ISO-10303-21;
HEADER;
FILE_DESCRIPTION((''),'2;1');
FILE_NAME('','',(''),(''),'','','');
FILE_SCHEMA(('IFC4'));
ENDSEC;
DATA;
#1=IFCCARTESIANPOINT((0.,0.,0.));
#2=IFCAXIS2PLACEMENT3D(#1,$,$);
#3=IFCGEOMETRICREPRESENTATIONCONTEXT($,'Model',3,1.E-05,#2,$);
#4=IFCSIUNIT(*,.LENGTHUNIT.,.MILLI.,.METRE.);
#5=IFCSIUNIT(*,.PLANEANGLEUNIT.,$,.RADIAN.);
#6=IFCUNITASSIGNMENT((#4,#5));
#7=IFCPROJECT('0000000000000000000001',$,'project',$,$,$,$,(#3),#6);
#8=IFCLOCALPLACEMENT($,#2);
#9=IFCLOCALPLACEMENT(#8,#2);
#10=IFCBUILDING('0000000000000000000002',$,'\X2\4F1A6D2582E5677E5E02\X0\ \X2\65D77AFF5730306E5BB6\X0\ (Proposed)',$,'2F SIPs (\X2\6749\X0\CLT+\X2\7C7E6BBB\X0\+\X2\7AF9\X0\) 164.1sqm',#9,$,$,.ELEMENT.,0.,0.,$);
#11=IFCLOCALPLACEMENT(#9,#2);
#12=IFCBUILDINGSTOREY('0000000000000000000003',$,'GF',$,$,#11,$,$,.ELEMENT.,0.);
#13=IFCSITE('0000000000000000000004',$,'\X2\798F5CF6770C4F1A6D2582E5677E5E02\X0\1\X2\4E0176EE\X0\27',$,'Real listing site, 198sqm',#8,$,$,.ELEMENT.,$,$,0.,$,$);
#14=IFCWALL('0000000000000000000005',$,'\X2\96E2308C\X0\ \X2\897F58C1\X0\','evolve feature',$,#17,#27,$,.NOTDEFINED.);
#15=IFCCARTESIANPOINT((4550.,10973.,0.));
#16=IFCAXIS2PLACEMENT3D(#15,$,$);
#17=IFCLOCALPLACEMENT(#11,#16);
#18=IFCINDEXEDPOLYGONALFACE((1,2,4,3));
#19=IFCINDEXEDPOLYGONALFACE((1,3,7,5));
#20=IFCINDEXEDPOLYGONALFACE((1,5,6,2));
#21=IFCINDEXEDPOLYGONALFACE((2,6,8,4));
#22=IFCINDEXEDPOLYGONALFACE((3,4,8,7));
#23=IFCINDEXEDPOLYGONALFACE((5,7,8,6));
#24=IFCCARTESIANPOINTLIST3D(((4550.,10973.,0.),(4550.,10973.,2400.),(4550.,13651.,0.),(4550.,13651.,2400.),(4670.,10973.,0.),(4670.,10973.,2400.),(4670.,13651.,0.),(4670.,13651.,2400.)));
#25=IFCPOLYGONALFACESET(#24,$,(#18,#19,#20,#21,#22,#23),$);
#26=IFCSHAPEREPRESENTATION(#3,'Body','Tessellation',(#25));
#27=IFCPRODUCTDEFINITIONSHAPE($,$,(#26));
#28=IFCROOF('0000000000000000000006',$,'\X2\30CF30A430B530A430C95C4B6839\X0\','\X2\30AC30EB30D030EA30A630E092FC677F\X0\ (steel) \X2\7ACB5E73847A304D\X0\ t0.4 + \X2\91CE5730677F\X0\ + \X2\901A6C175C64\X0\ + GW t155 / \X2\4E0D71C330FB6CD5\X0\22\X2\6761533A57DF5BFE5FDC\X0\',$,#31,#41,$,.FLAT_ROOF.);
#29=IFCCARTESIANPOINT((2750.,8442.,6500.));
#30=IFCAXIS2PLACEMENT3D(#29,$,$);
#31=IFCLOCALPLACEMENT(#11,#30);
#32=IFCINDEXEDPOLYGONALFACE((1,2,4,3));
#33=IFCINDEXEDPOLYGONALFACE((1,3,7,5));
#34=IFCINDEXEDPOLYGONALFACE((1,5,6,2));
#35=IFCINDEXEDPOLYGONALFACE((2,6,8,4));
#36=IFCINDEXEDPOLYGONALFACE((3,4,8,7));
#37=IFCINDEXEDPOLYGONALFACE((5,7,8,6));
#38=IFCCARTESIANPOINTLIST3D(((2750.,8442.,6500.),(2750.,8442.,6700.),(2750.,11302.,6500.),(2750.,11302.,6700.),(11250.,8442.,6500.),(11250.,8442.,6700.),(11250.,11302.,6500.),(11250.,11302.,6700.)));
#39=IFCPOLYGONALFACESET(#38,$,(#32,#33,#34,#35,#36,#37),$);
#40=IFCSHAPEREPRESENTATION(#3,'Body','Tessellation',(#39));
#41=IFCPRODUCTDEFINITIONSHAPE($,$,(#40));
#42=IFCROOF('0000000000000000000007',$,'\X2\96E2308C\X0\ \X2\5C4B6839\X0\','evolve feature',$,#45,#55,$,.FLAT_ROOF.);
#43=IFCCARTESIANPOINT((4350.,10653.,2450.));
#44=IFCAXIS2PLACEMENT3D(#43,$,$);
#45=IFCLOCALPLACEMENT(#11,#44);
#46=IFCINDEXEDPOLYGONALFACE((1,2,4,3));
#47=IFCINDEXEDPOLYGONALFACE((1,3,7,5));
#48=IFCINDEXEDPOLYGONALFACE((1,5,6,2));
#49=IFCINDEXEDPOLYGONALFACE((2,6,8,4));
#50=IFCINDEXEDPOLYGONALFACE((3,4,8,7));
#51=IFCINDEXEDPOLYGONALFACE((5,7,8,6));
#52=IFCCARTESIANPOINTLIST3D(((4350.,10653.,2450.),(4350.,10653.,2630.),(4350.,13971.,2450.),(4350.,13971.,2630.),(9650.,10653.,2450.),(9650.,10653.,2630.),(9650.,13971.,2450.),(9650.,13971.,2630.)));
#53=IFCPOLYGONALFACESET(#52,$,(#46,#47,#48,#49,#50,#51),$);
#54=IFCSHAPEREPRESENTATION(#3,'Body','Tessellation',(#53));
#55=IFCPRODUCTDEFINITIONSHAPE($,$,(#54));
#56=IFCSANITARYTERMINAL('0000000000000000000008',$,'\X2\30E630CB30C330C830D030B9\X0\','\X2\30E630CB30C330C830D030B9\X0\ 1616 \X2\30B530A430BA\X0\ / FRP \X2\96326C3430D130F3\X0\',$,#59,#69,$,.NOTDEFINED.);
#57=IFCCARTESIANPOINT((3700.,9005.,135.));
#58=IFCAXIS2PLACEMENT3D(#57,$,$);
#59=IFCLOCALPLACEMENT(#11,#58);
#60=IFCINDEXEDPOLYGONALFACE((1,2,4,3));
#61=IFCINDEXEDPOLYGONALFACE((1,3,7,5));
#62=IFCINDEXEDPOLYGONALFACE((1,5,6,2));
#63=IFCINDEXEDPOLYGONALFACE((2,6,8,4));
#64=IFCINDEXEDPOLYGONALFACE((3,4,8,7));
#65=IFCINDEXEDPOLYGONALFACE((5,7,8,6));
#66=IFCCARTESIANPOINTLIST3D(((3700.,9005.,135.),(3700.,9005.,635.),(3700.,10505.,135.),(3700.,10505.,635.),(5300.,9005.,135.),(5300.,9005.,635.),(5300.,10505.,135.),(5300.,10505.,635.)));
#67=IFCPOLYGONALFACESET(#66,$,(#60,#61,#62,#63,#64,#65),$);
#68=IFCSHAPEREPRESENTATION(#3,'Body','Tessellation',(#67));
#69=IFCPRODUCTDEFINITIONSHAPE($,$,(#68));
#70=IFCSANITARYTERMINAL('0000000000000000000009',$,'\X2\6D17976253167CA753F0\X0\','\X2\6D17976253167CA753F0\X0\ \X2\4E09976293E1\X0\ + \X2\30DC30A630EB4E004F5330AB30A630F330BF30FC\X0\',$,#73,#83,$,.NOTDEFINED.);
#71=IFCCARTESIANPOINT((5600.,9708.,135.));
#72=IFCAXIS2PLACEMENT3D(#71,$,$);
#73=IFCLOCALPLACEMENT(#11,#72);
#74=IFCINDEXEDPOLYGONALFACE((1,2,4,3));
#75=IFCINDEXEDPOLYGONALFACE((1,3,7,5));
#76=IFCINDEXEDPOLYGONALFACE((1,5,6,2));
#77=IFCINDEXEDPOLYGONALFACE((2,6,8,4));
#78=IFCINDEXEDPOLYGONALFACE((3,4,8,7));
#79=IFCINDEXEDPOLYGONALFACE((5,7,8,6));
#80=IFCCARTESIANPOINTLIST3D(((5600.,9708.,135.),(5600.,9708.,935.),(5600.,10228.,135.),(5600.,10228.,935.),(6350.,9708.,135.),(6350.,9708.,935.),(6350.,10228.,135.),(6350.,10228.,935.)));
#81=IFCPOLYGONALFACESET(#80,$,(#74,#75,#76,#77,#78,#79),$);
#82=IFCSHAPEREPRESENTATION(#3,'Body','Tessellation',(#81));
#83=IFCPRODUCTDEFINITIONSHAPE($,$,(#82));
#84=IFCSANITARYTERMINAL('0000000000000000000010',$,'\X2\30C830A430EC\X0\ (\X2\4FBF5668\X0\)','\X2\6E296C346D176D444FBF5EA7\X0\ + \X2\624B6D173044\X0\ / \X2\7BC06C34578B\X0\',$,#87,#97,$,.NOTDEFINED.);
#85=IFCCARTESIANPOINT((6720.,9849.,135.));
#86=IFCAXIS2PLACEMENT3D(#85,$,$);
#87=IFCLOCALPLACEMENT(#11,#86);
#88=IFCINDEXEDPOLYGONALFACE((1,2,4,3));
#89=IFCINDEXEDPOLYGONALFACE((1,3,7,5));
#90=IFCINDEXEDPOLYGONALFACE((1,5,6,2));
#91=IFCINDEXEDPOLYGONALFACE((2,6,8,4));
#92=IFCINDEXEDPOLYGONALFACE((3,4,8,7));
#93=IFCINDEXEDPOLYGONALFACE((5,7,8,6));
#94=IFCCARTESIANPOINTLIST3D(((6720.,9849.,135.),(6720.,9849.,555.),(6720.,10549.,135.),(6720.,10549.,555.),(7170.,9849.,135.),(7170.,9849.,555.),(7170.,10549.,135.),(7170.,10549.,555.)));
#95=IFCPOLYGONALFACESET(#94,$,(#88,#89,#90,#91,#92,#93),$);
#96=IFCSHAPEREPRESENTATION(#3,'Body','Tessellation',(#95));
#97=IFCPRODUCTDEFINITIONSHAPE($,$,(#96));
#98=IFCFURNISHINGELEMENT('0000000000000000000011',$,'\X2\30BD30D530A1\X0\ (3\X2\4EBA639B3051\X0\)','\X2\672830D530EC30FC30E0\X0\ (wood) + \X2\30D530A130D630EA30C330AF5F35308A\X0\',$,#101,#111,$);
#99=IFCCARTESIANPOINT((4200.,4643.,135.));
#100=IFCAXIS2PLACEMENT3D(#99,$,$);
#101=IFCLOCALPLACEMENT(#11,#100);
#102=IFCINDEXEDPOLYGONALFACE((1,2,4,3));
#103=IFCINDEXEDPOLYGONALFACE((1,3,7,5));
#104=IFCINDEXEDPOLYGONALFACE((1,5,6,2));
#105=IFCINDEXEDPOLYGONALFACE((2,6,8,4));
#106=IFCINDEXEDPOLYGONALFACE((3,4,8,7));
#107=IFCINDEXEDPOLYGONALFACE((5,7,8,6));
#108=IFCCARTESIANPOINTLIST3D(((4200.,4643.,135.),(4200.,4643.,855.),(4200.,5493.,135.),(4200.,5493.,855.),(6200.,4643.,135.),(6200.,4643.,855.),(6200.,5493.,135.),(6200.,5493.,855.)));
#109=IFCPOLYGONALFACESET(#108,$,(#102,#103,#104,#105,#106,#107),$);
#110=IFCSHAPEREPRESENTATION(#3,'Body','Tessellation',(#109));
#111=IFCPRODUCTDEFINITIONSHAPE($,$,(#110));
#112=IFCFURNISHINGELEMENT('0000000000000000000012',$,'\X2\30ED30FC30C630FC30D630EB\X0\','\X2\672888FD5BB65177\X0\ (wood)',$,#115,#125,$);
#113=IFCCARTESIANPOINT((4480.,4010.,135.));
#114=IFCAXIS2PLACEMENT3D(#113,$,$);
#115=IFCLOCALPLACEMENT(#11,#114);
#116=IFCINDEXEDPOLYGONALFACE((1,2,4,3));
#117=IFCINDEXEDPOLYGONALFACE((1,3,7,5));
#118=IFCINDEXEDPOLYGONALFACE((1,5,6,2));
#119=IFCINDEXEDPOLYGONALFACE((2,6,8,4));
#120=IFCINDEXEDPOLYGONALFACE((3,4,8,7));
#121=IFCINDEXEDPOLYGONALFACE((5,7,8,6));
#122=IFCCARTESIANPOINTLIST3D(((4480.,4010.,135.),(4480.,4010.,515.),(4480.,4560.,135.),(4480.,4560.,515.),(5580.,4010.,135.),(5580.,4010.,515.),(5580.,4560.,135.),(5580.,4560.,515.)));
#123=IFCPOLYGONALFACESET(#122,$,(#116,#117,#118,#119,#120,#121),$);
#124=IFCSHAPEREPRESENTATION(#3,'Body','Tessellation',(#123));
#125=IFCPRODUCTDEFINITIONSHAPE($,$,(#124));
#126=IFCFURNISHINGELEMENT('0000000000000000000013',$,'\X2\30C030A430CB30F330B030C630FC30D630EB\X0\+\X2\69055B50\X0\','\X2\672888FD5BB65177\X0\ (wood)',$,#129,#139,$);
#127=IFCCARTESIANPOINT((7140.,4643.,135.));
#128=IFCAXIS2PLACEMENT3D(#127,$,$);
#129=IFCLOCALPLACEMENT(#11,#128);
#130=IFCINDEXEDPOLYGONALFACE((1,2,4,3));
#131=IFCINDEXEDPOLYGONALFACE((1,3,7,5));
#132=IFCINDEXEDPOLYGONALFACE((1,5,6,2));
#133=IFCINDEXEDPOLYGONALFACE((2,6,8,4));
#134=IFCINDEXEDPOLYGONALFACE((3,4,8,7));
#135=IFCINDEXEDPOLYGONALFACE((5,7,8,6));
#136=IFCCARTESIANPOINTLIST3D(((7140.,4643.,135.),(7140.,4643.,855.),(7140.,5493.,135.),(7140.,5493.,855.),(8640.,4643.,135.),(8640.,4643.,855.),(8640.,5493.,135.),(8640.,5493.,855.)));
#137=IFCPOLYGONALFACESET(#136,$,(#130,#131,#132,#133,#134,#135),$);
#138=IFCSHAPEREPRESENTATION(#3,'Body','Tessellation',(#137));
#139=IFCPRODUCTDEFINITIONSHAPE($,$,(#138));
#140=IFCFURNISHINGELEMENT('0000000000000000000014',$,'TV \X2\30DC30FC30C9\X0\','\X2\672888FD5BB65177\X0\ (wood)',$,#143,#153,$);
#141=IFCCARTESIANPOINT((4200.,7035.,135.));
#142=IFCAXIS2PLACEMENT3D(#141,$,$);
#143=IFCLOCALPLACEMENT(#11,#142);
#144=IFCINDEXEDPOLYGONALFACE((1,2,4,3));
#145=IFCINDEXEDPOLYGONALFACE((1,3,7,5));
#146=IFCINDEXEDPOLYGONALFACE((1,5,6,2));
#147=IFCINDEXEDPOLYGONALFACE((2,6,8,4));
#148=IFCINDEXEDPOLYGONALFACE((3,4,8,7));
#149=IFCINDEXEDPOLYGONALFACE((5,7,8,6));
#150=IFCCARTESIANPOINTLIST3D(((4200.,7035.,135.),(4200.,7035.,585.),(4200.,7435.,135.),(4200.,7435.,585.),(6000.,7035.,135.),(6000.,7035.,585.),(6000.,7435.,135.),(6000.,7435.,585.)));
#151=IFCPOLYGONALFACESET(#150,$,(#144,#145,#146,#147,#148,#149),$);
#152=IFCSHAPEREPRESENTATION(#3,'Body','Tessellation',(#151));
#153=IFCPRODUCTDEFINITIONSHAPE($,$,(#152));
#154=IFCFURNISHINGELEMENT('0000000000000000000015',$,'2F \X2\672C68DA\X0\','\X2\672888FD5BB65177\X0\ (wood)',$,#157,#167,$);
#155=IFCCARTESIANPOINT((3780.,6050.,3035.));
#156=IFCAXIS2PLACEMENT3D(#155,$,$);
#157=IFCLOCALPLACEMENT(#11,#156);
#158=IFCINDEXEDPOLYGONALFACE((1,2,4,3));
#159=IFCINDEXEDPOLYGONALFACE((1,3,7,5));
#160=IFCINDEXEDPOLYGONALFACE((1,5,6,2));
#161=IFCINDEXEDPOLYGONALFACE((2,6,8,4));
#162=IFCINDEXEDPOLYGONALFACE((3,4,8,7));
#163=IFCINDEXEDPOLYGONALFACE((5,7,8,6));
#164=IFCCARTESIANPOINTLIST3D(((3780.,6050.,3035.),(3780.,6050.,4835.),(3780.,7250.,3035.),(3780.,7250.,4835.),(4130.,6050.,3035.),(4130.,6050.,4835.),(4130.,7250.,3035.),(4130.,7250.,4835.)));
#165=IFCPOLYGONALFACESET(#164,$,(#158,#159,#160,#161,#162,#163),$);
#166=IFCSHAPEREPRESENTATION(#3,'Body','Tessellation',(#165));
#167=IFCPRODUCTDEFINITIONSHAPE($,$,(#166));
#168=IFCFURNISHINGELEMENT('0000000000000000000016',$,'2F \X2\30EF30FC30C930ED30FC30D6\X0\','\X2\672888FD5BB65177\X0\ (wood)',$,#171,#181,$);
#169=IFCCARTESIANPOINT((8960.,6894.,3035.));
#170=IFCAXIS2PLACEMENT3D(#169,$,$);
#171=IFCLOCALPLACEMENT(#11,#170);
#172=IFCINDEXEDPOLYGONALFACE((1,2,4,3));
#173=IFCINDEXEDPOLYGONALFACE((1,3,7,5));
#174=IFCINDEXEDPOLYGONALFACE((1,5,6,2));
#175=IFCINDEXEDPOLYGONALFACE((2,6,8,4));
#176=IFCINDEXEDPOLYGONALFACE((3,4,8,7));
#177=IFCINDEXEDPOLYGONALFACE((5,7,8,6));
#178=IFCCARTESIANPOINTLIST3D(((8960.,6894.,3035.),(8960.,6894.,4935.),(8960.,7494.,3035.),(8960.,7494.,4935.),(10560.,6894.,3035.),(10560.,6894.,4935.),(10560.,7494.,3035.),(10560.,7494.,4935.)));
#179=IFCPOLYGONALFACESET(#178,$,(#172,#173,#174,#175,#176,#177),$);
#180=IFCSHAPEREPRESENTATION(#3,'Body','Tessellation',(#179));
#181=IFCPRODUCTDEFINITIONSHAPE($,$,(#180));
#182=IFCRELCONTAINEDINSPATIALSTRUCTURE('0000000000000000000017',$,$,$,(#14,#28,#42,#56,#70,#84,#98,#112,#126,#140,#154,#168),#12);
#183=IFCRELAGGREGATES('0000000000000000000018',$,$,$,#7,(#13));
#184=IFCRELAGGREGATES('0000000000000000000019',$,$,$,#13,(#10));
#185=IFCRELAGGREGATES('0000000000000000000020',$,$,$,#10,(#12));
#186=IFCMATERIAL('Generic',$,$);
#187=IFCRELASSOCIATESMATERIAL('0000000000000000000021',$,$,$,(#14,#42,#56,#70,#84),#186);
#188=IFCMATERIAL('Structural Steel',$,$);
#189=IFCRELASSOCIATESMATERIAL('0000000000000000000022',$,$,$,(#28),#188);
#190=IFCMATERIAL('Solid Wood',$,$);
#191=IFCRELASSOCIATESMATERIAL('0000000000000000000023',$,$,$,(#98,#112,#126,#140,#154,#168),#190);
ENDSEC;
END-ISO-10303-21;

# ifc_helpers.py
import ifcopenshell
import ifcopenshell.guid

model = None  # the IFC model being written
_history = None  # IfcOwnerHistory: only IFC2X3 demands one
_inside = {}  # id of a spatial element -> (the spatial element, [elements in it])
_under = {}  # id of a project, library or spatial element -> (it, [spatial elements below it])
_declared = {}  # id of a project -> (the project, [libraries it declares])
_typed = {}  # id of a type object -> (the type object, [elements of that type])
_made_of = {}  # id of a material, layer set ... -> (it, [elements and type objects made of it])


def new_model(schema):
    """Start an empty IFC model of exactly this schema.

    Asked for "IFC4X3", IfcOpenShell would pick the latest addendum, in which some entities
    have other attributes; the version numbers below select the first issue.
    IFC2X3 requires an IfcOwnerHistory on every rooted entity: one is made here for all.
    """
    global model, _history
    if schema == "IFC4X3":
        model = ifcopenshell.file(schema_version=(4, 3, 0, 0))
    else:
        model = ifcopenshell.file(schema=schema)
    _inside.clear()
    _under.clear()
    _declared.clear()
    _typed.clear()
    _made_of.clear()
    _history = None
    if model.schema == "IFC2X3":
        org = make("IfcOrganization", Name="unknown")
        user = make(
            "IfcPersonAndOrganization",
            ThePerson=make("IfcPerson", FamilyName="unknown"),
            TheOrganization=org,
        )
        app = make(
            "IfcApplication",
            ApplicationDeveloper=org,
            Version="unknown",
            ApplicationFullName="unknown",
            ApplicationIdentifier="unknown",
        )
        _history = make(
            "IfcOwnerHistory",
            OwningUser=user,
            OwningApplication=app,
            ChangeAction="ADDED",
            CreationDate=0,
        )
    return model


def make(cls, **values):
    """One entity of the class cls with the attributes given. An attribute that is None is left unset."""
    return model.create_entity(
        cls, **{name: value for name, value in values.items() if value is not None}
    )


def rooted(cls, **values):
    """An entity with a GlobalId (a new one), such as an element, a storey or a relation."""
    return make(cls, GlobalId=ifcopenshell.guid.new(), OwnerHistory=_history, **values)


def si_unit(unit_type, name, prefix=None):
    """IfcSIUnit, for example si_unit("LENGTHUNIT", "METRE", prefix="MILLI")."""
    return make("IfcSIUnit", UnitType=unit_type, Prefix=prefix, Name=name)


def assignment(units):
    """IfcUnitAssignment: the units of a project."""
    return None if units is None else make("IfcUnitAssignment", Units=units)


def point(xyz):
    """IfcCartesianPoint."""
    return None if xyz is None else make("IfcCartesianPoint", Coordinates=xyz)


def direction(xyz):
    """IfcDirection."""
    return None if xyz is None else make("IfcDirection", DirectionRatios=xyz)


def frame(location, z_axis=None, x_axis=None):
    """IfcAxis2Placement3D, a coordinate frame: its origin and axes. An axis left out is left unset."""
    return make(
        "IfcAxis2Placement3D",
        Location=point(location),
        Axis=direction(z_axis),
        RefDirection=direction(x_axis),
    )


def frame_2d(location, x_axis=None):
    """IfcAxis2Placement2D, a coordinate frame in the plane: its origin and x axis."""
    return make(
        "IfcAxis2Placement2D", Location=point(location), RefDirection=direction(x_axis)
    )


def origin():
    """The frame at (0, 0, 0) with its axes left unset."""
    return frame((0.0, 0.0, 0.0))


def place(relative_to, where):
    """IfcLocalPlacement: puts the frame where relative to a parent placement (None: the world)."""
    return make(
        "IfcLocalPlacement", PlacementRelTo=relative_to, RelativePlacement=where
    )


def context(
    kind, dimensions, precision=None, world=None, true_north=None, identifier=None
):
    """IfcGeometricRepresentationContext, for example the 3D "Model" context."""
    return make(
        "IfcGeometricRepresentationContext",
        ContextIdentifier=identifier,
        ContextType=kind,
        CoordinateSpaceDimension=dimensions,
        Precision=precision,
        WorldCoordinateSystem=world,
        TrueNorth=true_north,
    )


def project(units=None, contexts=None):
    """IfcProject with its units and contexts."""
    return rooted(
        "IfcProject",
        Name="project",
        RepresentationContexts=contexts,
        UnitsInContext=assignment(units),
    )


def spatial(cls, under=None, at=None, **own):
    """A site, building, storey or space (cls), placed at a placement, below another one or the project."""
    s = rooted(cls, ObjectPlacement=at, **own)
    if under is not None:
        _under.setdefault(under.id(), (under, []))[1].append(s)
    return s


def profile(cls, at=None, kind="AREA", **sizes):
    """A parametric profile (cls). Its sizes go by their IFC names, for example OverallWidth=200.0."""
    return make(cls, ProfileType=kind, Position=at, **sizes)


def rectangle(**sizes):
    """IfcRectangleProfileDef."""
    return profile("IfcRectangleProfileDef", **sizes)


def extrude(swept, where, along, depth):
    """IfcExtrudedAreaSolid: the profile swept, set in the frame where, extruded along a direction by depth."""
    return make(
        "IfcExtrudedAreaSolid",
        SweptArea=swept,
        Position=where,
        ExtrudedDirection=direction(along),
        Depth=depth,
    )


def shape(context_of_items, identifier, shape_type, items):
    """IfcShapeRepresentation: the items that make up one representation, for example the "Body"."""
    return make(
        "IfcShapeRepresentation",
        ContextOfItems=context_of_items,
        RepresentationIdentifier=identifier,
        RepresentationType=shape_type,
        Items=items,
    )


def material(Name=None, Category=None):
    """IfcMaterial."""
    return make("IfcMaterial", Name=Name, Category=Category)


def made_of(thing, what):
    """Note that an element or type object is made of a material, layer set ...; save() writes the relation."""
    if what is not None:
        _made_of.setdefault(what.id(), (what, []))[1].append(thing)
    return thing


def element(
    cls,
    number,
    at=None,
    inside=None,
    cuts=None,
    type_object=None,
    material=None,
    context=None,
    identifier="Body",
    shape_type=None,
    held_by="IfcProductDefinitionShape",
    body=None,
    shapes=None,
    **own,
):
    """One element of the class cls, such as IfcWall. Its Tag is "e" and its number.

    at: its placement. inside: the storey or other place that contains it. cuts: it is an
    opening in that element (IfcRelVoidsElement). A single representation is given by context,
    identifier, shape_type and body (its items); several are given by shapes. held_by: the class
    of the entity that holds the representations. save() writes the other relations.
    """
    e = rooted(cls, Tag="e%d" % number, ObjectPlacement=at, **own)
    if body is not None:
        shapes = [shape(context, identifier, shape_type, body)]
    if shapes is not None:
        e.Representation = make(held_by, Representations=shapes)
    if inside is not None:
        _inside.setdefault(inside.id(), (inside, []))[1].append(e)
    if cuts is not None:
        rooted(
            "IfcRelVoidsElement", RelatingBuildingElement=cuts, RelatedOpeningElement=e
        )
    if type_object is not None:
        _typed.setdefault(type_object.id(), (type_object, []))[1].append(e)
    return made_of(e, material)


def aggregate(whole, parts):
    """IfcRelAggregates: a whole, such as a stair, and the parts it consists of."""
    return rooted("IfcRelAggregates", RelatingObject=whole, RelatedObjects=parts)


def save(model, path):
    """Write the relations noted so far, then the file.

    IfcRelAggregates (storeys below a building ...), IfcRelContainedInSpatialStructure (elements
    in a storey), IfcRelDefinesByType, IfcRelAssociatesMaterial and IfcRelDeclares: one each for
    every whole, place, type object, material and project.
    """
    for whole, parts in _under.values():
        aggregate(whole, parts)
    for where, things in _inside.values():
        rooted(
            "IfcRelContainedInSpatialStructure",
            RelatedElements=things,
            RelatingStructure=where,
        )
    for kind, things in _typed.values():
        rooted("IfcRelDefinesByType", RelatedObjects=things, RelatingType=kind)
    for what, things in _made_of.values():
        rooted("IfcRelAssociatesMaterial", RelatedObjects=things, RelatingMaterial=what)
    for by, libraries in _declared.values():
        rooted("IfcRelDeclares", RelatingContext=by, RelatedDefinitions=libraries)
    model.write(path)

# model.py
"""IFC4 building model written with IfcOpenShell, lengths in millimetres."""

from ifc_helpers import new_model, si_unit, frame, frame_2d, origin, place, context, project, spatial, rectangle, extrude, material, element, save


model = new_model("IFC4")

# Units and contexts
model_context = context("Model", 3, precision=1e-05, world=origin())
ifc_project = project(units=[si_unit("LENGTHUNIT", "METRE", prefix="MILLI"), si_unit("PLANEANGLEUNIT", "RADIAN")], contexts=[model_context])

# Site, building, storey
site_placement = place(None, origin())
site = spatial("IfcSite", under=ifc_project, at=site_placement, Name="福島県会津若松市1丁目27", ObjectType="Real listing site, 198sqm", CompositionType="ELEMENT", RefElevation=0.0)
building_placement = place(site_placement, origin())
building = spatial("IfcBuilding", under=site, at=building_placement, Name="会津若松市 旗竿地の家 (Proposed)", ObjectType="2F SIPs (杉CLT+籾殻+竹) 164.1sqm", CompositionType="ELEMENT", ElevationOfRefHeight=0.0, ElevationOfTerrain=0.0)
storey_placement = place(building_placement, origin())
storey = spatial("IfcBuildingStorey", under=building, at=storey_placement, Name="GF", CompositionType="ELEMENT", Elevation=0.0)

# Shared definitions
ifc_material_1 = material(Name="Generic")

# Shared definitions
ifc_material_2 = material(Name="Solid Wood")

# Wall
wall_1_placement = place(storey_placement, frame((4550.0, 10973.0, 0.0)))
element("IfcWall", 1, at=wall_1_placement, inside=storey, material=ifc_material_1, Name="離れ 西壁", Description="evolve feature", PredefinedType="NOTDEFINED", context=model_context, shape_type="SweptSolid", body=[
    extrude(rectangle(XDim=120.0, YDim=2678.0, at=frame_2d((60.0, 1339.0))), frame((4550.0, 10973.0, 0.0)), (0.0, 0.0, 1.0), 2400.0),
])

# Roofs
ifc_material_3 = material(Name="Structural Steel")
roof_1_placement = place(storey_placement, frame((2750.0, 8442.0, 6500.0)))
element("IfcRoof", 2, at=roof_1_placement, inside=storey, material=ifc_material_3, Name="ハイサイド屋根", Description="ガルバリウム鋼板 (steel) 立平葺き t0.4 + 野地板 + 通気層 + GW t155 / 不燃・法22条区域対応", PredefinedType="FLAT_ROOF", context=model_context, shape_type="SweptSolid", body=[
    extrude(rectangle(XDim=8500.0, YDim=2860.0, at=frame_2d((4250.0, 1430.0))), frame((2750.0, 8442.0, 6500.0)), (0.0, 0.0, 1.0), 200.0),
])
roof_2_placement = place(storey_placement, frame((4350.0, 10653.0, 2450.0)))
element("IfcRoof", 3, at=roof_2_placement, inside=storey, material=ifc_material_1, Name="離れ 屋根", Description="evolve feature", PredefinedType="FLAT_ROOF", context=model_context, shape_type="SweptSolid", body=[
    extrude(rectangle(XDim=5300.0, YDim=3318.0, at=frame_2d((2650.0, 1659.0))), frame((4350.0, 10653.0, 2450.0)), (0.0, 0.0, 1.0), 180.0),
])

# Sanitary terminals
sanitary_terminal_1_placement = place(storey_placement, frame((3700.0, 9005.0, 135.0)))
element("IfcSanitaryTerminal", 4, at=sanitary_terminal_1_placement, inside=storey, material=ifc_material_1, Name="ユニットバス", Description="ユニットバス 1616 サイズ / FRP 防水パン", PredefinedType="NOTDEFINED", context=model_context, shape_type="SweptSolid", body=[
    extrude(rectangle(XDim=1600.0, YDim=1500.0, at=frame_2d((800.0, 750.0))), frame((3700.0, 9005.0, 135.0)), (0.0, 0.0, 1.0), 500.0),
])
sanitary_terminal_2_placement = place(storey_placement, frame((5600.0, 9708.0, 135.0)))
element("IfcSanitaryTerminal", 5, at=sanitary_terminal_2_placement, inside=storey, material=ifc_material_1, Name="洗面化粧台", Description="洗面化粧台 三面鏡 + ボウル一体カウンター", PredefinedType="NOTDEFINED", context=model_context, shape_type="SweptSolid", body=[
    extrude(rectangle(XDim=750.0, YDim=520.0, at=frame_2d((375.0, 260.0))), frame((5600.0, 9708.0, 135.0)), (0.0, 0.0, 1.0), 800.0),
])
sanitary_terminal_3_placement = place(storey_placement, frame((6720.0, 9849.0, 135.0)))
element("IfcSanitaryTerminal", 6, at=sanitary_terminal_3_placement, inside=storey, material=ifc_material_1, Name="トイレ (便器)", Description="温水洗浄便座 + 手洗い / 節水型", PredefinedType="NOTDEFINED", context=model_context, shape_type="SweptSolid", body=[
    extrude(rectangle(XDim=450.0, YDim=700.0, at=frame_2d((225.0, 350.0))), frame((6720.0, 9849.0, 135.0)), (0.0, 0.0, 1.0), 420.0),
])

# Furnishing elements
furnishing_1_placement = place(storey_placement, frame((4200.0, 4643.0, 135.0)))
element("IfcFurnishingElement", 7, at=furnishing_1_placement, inside=storey, material=ifc_material_2, Name="ソファ (3人掛け)", Description="木フレーム (wood) + ファブリック張り", context=model_context, shape_type="SweptSolid", body=[
    extrude(rectangle(XDim=2000.0, YDim=850.0, at=frame_2d((1000.0, 425.0))), frame((4200.0, 4643.0, 135.0)), (0.0, 0.0, 1.0), 720.0),
])
furnishing_2_placement = place(storey_placement, frame((4480.0, 4010.0, 135.0)))
element("IfcFurnishingElement", 8, at=furnishing_2_placement, inside=storey, material=ifc_material_2, Name="ローテーブル", Description="木製家具 (wood)", context=model_context, shape_type="SweptSolid", body=[
    extrude(rectangle(XDim=1100.0, YDim=550.0, at=frame_2d((550.0, 275.0))), frame((4480.0, 4010.0, 135.0)), (0.0, 0.0, 1.0), 380.0),
])
furnishing_3_placement = place(storey_placement, frame((7140.0, 4643.0, 135.0)))
element("IfcFurnishingElement", 9, at=furnishing_3_placement, inside=storey, material=ifc_material_2, Name="ダイニングテーブル+椅子", Description="木製家具 (wood)", context=model_context, shape_type="SweptSolid", body=[
    extrude(rectangle(XDim=1500.0, YDim=850.0, at=frame_2d((750.0, 425.0))), frame((7140.0, 4643.0, 135.0)), (0.0, 0.0, 1.0), 720.0),
])
furnishing_4_placement = place(storey_placement, frame((4200.0, 7035.0, 135.0)))
element("IfcFurnishingElement", 10, at=furnishing_4_placement, inside=storey, material=ifc_material_2, Name="TV ボード", Description="木製家具 (wood)", context=model_context, shape_type="SweptSolid", body=[
    extrude(rectangle(XDim=1800.0, YDim=400.0, at=frame_2d((900.0, 200.0))), frame((4200.0, 7035.0, 135.0)), (0.0, 0.0, 1.0), 450.0),
])
furnishing_5_placement = place(storey_placement, frame((3780.0, 6050.0, 3035.0)))
element("IfcFurnishingElement", 11, at=furnishing_5_placement, inside=storey, material=ifc_material_2, Name="2F 本棚", Description="木製家具 (wood)", context=model_context, shape_type="SweptSolid", body=[
    extrude(rectangle(XDim=350.0, YDim=1200.0, at=frame_2d((175.0, 600.0))), frame((3780.0, 6050.0, 3035.0)), (0.0, 0.0, 1.0), 1800.0),
])
furnishing_6_placement = place(storey_placement, frame((8960.0, 6894.0, 3035.0)))
element("IfcFurnishingElement", 12, at=furnishing_6_placement, inside=storey, material=ifc_material_2, Name="2F ワードローブ", Description="木製家具 (wood)", context=model_context, shape_type="SweptSolid", body=[
    extrude(rectangle(XDim=1600.0, YDim=600.0, at=frame_2d((800.0, 300.0))), frame((8960.0, 6894.0, 3035.0)), (0.0, 0.0, 1.0), 1900.0),
])

save(model, "model.ifc")
